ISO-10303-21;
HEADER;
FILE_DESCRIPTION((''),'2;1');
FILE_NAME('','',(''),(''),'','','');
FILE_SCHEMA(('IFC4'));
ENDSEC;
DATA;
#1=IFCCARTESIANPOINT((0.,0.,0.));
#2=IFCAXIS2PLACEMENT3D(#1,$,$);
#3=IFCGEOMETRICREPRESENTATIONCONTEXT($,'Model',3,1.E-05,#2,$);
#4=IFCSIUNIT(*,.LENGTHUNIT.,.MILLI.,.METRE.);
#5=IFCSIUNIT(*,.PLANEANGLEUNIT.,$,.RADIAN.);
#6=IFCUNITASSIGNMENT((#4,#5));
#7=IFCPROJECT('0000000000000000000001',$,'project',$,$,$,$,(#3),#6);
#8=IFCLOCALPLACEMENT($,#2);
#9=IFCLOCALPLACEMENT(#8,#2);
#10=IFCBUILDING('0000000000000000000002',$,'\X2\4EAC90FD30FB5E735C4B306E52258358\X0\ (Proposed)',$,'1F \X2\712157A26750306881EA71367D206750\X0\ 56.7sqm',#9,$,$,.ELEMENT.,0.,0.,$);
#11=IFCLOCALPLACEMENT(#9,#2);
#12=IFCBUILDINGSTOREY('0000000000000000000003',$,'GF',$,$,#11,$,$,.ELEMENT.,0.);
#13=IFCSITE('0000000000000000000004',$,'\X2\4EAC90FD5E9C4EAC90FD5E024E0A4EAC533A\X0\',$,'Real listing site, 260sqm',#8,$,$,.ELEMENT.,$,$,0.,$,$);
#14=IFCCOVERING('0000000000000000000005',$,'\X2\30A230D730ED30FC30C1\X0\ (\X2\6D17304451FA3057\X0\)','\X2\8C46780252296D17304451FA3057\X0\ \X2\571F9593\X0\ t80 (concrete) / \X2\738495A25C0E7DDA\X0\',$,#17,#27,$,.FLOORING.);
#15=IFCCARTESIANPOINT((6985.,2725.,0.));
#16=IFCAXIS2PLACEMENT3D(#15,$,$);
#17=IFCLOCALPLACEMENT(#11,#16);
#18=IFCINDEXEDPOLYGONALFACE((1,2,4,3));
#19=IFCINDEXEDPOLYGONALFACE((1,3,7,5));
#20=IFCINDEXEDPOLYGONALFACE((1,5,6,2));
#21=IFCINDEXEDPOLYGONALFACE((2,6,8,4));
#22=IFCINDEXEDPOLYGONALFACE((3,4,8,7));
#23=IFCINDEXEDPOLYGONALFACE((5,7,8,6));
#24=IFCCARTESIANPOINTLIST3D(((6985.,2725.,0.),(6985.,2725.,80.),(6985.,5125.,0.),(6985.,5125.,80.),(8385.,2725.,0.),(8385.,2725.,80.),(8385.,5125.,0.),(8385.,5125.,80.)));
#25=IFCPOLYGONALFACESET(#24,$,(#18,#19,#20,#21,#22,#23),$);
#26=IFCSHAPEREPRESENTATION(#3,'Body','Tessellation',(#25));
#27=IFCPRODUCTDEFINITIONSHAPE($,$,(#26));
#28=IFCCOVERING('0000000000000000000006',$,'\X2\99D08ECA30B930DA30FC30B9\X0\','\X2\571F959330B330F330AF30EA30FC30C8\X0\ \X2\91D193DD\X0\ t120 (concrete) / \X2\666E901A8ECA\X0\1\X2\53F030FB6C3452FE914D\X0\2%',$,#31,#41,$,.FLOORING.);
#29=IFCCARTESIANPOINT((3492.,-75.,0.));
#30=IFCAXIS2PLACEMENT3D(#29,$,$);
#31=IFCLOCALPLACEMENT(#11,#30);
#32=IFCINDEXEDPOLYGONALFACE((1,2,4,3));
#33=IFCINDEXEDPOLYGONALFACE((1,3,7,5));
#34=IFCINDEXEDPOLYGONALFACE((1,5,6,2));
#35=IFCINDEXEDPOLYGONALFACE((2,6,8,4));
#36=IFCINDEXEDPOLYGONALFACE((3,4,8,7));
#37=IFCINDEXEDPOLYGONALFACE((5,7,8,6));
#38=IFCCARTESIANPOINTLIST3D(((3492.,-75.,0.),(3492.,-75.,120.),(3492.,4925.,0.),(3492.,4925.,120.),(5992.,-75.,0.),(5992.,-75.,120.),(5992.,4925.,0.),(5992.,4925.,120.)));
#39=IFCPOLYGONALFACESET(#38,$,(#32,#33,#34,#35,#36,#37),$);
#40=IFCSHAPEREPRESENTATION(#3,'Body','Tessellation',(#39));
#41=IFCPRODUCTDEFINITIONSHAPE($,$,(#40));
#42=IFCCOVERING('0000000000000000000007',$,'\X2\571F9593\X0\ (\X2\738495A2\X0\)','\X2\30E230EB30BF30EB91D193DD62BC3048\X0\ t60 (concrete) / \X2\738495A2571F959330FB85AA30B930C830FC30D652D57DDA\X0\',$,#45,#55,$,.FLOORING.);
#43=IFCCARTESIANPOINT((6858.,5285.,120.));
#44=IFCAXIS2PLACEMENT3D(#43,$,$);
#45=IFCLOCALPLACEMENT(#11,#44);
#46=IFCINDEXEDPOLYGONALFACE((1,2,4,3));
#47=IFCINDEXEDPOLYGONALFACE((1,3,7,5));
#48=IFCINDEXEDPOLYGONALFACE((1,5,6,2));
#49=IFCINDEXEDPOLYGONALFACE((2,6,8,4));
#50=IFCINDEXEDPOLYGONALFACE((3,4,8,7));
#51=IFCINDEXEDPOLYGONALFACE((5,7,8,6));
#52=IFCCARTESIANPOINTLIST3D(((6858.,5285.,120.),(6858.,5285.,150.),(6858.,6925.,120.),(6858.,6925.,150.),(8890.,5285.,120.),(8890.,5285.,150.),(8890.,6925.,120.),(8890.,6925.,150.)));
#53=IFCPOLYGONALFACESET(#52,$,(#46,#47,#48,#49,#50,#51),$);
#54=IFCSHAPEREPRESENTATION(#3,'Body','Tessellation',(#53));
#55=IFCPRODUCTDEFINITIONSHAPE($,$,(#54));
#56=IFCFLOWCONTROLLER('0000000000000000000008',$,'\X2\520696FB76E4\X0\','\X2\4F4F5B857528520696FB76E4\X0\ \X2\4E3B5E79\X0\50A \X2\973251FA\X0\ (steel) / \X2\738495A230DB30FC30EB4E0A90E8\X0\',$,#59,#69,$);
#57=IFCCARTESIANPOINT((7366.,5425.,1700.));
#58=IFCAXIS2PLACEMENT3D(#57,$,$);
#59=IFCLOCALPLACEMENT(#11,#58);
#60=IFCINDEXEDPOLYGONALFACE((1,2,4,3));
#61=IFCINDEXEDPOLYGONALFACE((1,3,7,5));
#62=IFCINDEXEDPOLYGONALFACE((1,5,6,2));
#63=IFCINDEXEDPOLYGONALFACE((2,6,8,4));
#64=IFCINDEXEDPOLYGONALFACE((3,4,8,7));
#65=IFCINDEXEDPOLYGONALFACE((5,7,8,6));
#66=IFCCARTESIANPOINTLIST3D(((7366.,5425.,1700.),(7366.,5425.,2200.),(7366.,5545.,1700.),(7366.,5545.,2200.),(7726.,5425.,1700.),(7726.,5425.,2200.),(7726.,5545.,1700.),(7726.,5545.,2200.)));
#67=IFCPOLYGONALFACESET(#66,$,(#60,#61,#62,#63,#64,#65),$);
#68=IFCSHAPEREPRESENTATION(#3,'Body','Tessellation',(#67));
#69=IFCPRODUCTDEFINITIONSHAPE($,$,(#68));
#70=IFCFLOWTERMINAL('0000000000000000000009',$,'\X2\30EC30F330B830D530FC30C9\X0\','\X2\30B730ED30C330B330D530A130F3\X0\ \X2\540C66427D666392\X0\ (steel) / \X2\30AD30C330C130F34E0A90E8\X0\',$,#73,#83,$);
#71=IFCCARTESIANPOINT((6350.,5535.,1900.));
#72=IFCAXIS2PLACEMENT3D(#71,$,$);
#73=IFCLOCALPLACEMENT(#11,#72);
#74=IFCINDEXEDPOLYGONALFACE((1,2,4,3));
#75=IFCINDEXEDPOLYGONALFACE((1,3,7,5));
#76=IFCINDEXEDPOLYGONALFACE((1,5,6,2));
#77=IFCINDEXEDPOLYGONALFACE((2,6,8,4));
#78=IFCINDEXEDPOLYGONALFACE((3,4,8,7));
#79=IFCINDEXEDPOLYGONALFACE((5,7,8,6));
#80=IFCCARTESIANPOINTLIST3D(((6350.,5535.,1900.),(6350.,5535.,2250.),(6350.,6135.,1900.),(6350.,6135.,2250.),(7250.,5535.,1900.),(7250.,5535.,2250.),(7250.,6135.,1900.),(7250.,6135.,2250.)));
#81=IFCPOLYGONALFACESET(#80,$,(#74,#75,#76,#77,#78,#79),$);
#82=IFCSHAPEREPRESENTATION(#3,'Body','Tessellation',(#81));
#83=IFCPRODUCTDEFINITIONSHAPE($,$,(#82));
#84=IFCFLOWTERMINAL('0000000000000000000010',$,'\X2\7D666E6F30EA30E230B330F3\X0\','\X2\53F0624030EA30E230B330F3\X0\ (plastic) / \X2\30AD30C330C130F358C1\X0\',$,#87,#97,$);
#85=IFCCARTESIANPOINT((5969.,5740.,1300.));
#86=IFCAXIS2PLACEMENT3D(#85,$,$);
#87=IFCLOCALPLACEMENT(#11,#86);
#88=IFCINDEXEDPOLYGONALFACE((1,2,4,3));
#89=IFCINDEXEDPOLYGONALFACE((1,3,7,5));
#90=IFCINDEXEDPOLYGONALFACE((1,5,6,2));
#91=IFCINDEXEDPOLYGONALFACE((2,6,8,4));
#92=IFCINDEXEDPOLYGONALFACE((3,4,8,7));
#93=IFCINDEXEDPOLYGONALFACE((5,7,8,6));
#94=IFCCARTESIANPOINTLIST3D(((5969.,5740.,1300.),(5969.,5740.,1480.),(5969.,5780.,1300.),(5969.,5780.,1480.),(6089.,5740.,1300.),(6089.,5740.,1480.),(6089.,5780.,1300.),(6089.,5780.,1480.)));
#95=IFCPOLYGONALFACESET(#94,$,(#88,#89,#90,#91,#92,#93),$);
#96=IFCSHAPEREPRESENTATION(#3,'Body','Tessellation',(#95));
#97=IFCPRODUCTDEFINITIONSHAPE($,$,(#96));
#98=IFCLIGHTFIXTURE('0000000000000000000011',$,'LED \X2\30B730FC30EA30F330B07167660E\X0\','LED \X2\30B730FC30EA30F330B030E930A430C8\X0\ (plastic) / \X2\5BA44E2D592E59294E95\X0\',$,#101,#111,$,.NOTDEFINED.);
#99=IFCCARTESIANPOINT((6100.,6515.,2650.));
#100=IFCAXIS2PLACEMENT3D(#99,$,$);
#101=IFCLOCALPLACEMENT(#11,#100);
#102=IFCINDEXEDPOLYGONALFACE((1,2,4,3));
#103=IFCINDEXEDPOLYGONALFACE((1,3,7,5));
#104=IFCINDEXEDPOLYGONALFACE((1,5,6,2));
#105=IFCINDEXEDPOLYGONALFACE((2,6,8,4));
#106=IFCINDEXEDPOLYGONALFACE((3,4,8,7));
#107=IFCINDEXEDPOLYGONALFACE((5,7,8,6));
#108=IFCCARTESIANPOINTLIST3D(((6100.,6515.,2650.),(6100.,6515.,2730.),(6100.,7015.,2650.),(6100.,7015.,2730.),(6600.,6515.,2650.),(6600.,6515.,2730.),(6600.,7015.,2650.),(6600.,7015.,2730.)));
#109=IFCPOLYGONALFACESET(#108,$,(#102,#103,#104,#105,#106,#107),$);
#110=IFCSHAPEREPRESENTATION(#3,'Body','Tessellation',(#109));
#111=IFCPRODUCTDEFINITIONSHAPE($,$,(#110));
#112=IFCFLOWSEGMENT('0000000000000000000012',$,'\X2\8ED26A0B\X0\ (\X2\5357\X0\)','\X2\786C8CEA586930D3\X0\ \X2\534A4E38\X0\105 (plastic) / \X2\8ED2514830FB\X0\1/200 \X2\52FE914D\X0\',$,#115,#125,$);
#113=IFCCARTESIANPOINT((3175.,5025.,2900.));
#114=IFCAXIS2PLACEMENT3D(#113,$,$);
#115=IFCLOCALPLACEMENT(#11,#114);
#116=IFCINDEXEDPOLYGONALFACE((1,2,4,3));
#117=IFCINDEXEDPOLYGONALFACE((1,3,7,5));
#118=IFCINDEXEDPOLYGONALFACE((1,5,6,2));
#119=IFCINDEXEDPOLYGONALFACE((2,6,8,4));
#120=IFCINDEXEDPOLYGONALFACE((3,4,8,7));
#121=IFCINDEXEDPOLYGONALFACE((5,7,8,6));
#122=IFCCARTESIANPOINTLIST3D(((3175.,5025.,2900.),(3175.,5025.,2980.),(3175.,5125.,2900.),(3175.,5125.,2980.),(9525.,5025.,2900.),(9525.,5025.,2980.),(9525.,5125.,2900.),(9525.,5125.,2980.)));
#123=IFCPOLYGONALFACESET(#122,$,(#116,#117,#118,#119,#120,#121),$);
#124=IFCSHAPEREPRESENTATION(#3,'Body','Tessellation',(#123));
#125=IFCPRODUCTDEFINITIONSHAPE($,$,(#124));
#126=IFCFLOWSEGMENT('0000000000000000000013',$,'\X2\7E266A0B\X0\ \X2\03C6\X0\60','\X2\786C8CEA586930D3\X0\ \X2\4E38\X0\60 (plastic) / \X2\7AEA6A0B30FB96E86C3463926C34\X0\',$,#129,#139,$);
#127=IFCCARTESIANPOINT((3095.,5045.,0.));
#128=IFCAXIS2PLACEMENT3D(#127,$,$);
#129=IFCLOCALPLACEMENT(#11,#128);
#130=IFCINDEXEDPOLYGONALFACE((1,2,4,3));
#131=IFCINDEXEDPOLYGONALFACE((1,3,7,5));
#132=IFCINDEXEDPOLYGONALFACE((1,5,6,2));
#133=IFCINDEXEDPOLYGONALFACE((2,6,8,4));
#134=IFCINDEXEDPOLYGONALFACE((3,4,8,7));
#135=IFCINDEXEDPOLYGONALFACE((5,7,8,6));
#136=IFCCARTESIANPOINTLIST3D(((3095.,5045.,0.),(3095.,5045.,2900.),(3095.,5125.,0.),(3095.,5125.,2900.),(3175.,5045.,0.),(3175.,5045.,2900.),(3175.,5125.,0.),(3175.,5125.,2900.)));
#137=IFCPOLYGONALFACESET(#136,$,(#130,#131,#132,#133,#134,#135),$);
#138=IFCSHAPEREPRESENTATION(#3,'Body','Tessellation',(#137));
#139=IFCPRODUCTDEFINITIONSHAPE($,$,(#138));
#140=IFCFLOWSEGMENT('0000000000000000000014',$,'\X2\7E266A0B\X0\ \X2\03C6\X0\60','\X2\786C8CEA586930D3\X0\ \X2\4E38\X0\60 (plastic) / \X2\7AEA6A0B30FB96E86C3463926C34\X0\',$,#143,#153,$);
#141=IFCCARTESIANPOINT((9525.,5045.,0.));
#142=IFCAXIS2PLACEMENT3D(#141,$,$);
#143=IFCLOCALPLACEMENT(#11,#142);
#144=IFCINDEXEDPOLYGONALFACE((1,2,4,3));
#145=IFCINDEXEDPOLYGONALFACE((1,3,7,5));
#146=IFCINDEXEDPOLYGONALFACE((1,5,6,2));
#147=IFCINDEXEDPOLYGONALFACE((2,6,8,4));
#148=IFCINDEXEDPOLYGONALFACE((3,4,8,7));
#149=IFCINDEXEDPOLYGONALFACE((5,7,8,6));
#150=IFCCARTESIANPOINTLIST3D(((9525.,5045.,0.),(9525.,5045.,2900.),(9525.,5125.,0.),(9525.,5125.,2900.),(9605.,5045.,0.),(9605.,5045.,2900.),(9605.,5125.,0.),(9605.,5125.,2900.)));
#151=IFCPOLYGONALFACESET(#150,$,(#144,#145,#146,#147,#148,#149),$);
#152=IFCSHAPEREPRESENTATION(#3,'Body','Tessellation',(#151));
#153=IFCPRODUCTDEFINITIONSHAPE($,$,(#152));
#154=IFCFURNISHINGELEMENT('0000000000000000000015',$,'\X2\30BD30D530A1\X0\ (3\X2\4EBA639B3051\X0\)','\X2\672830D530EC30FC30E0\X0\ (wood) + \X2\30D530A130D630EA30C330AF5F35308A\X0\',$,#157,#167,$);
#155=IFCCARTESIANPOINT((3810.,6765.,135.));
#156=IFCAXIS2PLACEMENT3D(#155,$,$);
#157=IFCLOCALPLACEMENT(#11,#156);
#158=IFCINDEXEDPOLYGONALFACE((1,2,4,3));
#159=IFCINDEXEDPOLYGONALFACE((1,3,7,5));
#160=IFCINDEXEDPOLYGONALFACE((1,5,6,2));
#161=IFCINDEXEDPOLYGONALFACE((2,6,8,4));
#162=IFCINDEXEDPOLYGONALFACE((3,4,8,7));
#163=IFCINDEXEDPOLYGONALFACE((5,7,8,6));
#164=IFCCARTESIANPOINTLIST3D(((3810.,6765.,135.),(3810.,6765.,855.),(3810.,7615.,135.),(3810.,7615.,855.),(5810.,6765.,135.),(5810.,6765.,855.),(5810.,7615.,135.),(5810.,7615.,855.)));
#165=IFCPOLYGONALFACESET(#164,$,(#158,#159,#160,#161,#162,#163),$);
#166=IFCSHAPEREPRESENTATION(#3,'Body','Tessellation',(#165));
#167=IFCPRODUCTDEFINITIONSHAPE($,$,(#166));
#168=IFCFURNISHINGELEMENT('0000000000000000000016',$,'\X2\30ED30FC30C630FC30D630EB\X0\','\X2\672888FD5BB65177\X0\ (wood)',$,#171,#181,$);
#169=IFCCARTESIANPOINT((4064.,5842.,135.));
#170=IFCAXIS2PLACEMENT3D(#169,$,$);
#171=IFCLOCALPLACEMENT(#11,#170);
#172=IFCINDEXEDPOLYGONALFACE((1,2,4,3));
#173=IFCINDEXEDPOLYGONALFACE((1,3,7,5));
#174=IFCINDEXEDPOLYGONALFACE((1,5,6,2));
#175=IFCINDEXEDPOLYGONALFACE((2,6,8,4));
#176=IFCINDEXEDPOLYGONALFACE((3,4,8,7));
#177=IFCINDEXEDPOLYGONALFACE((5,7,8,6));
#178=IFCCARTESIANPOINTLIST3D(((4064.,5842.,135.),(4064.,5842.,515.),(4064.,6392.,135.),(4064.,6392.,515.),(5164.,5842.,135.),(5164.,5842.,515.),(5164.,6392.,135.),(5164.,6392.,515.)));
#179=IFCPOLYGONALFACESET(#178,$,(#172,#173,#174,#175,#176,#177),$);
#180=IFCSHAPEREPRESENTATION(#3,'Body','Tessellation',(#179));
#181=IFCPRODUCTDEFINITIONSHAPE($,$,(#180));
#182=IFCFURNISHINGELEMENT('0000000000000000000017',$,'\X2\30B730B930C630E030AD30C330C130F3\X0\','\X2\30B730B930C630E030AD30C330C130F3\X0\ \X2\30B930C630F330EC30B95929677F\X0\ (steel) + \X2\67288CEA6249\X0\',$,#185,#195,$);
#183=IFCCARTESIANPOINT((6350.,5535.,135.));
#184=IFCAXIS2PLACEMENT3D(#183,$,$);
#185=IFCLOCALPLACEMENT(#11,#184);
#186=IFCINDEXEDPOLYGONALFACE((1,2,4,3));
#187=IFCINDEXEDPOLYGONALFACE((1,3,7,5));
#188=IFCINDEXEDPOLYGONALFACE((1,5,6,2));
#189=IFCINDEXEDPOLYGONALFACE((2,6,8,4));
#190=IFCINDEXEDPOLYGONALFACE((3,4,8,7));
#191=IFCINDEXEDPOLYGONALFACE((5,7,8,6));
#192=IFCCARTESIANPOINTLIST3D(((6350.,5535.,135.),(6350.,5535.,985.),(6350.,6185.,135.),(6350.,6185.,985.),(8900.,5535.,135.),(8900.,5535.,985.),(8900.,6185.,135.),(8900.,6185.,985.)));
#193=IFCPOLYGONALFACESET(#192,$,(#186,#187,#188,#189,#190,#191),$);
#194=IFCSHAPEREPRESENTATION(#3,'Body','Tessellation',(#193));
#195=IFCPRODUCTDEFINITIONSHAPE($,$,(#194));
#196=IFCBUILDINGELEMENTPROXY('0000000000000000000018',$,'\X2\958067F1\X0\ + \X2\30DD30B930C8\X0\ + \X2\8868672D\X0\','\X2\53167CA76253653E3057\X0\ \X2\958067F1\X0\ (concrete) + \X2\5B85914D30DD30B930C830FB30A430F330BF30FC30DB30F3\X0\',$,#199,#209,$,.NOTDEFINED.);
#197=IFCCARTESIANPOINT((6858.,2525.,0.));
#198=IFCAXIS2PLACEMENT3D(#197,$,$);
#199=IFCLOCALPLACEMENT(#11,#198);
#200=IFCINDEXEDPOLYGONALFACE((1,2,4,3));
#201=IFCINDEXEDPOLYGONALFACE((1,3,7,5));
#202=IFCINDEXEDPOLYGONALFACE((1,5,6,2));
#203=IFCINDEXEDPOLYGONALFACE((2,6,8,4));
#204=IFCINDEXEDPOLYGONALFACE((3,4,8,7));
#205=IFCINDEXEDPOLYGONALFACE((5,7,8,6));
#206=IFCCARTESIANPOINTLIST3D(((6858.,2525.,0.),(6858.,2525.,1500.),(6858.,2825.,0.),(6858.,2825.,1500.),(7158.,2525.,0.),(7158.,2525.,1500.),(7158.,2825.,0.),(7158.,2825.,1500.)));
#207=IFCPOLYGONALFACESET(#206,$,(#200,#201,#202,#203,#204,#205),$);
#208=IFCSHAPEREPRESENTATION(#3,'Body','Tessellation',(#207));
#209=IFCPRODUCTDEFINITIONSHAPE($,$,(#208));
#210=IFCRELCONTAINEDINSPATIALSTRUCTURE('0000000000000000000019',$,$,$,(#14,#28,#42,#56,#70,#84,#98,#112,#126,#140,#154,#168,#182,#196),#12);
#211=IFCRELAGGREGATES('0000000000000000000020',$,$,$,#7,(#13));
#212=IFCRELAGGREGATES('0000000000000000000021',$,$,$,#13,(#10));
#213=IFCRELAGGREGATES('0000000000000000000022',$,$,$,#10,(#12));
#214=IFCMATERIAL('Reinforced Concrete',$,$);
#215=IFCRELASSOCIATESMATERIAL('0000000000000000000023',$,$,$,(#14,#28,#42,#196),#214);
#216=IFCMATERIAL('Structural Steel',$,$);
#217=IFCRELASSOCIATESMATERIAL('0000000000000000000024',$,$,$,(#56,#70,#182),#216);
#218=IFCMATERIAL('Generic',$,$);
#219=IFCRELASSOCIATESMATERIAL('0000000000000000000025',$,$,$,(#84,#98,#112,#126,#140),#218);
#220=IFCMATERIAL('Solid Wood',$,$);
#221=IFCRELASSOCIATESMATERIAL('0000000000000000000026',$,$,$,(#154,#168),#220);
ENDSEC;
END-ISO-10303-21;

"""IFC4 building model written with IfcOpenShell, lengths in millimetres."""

from ifc_helpers import new_model, si_unit, frame, frame_2d, origin, place, context, project, spatial, rectangle, extrude, material, element, save


model = new_model("IFC4")

# Units and contexts
model_context = context("Model", 3, precision=1e-05, world=origin())
ifc_project = project(units=[si_unit("LENGTHUNIT", "METRE", prefix="MILLI"), si_unit("PLANEANGLEUNIT", "RADIAN")], contexts=[model_context])

# Site, building, storey
site_placement = place(None, origin())
site = spatial("IfcSite", under=ifc_project, at=site_placement, Name="京都府京都市上京区", ObjectType="Real listing site, 260sqm", CompositionType="ELEMENT", RefElevation=0.0)
building_placement = place(site_placement, origin())
building = spatial("IfcBuilding", under=site, at=building_placement, Name="京都・平屋の別荘 (Proposed)", ObjectType="1F 無垢材と自然素材 56.7sqm", CompositionType="ELEMENT", ElevationOfRefHeight=0.0, ElevationOfTerrain=0.0)
storey_placement = place(building_placement, origin())
storey = spatial("IfcBuildingStorey", under=building, at=storey_placement, Name="GF", CompositionType="ELEMENT", Elevation=0.0)

# Shared definitions
ifc_material_1 = material(Name="Solid Wood")

# Shared definitions
ifc_material_2 = material(Name="Reinforced Concrete")

# Shared definitions
ifc_material_3 = material(Name="Structural Steel")

# Coverings
ifc_material_4 = material(Name="Generic")
covering_1_placement = place(storey_placement, frame((6985.0, 2725.0, 0.0)))
element("IfcCovering", 1, at=covering_1_placement, inside=storey, material=ifc_material_2, Name="アプローチ (洗い出し)", Description="豆砂利洗い出し 土間 t80 (concrete) / 玄関導線", PredefinedType="FLOORING", context=model_context, shape_type="SweptSolid", body=[
    extrude(rectangle(XDim=1400.0, YDim=2400.0, at=frame_2d((700.0, 1200.0))), frame((6985.0, 2725.0, 0.0)), (0.0, 0.0, 1.0), 80.0),
])
covering_2_placement = place(storey_placement, frame((3492.0, -75.0, 0.0)))
element("IfcCovering", 2, at=covering_2_placement, inside=storey, material=ifc_material_2, Name="駐車スペース", Description="土間コンクリート 金鏝 t120 (concrete) / 普通車1台・水勾配2%", PredefinedType="FLOORING", context=model_context, shape_type="SweptSolid", body=[
    extrude(rectangle(XDim=2500.0, YDim=5000.0, at=frame_2d((1250.0, 2500.0))), frame((3492.0, -75.0, 0.0)), (0.0, 0.0, 1.0), 120.0),
])
covering_3_placement = place(storey_placement, frame((6858.0, 5285.0, 120.0)))
element("IfcCovering", 3, at=covering_3_placement, inside=storey, material=ifc_material_2, Name="土間 (玄関)", Description="モルタル金鏝押え t60 (concrete) / 玄関土間・薪ストーブ動線", PredefinedType="FLOORING", context=model_context, shape_type="SweptSolid", body=[
    extrude(rectangle(XDim=2032.0, YDim=1640.0, at=frame_2d((1016.0, 820.0))), frame((6858.0, 5285.0, 120.0)), (0.0, 0.0, 1.0), 30.0),
])

# Flow controller
flow_controller_placement = place(storey_placement, frame((7366.0, 5425.0, 1700.0)))
element("IfcFlowController", 4, at=flow_controller_placement, inside=storey, material=ifc_material_3, Name="分電盤", Description="住宅用分電盤 主幹50A 露出 (steel) / 玄関ホール上部", context=model_context, shape_type="SweptSolid", body=[
    extrude(rectangle(XDim=360.0, YDim=120.0, at=frame_2d((180.0, 60.0))), frame((7366.0, 5425.0, 1700.0)), (0.0, 0.0, 1.0), 500.0),
])

# Flow terminals
flow_terminal_1_placement = place(storey_placement, frame((6350.0, 5535.0, 1900.0)))
element("IfcFlowTerminal", 5, at=flow_terminal_1_placement, inside=storey, material=ifc_material_3, Name="レンジフード", Description="シロッコファン 同時給排 (steel) / キッチン上部", context=model_context, shape_type="SweptSolid", body=[
    extrude(rectangle(XDim=900.0, YDim=600.0, at=frame_2d((450.0, 300.0))), frame((6350.0, 5535.0, 1900.0)), (0.0, 0.0, 1.0), 350.0),
])
flow_terminal_2_placement = place(storey_placement, frame((5969.0, 5740.0, 1300.0)))
element("IfcFlowTerminal", 6, at=flow_terminal_2_placement, inside=storey, material=ifc_material_4, Name="給湯リモコン", Description="台所リモコン (plastic) / キッチン壁", context=model_context, shape_type="SweptSolid", body=[
    extrude(rectangle(XDim=120.0, YDim=40.0, at=frame_2d((60.0, 20.0))), frame((5969.0, 5740.0, 1300.0)), (0.0, 0.0, 1.0), 180.0),
])

# Light fixture
light_fixture_placement = place(storey_placement, frame((6100.0, 6515.0, 2650.0)))
element("IfcLightFixture", 7, at=light_fixture_placement, inside=storey, material=ifc_material_4, Name="LED シーリング照明", Description="LED シーリングライト (plastic) / 室中央天井", PredefinedType="NOTDEFINED", context=model_context, shape_type="SweptSolid", body=[
    extrude(rectangle(XDim=500.0, YDim=500.0, at=frame_2d((250.0, 250.0))), frame((6100.0, 6515.0, 2650.0)), (0.0, 0.0, 1.0), 80.0),
])

# Flow segments
flow_segment_1_placement = place(storey_placement, frame((3175.0, 5025.0, 2900.0)))
element("IfcFlowSegment", 8, at=flow_segment_1_placement, inside=storey, material=ifc_material_4, Name="軒樋 (南)", Description="硬質塩ビ 半丸105 (plastic) / 軒先・1/200 勾配", context=model_context, shape_type="SweptSolid", body=[
    extrude(rectangle(XDim=6350.0, YDim=100.0, at=frame_2d((3175.0, 50.0))), frame((3175.0, 5025.0, 2900.0)), (0.0, 0.0, 1.0), 80.0),
])
flow_segment_2_placement = place(storey_placement, frame((3095.0, 5045.0, 0.0)))
element("IfcFlowSegment", 9, at=flow_segment_2_placement, inside=storey, material=ifc_material_4, Name="縦樋 φ60", Description="硬質塩ビ 丸60 (plastic) / 竪樋・雨水排水", context=model_context, shape_type="SweptSolid", body=[
    extrude(rectangle(XDim=80.0, YDim=80.0, at=frame_2d((40.0, 40.0))), frame((3095.0, 5045.0, 0.0)), (0.0, 0.0, 1.0), 2900.0),
])
flow_segment_3_placement = place(storey_placement, frame((9525.0, 5045.0, 0.0)))
element("IfcFlowSegment", 10, at=flow_segment_3_placement, inside=storey, material=ifc_material_4, Name="縦樋 φ60", Description="硬質塩ビ 丸60 (plastic) / 竪樋・雨水排水", context=model_context, shape_type="SweptSolid", body=[
    extrude(rectangle(XDim=80.0, YDim=80.0, at=frame_2d((40.0, 40.0))), frame((9525.0, 5045.0, 0.0)), (0.0, 0.0, 1.0), 2900.0),
])

# Furnishing elements
furnishing_1_placement = place(storey_placement, frame((3810.0, 6765.0, 135.0)))
element("IfcFurnishingElement", 11, at=furnishing_1_placement, inside=storey, material=ifc_material_1, Name="ソファ (3人掛け)", Description="木フレーム (wood) + ファブリック張り", context=model_context, shape_type="SweptSolid", body=[
    extrude(rectangle(XDim=2000.0, YDim=850.0, at=frame_2d((1000.0, 425.0))), frame((3810.0, 6765.0, 135.0)), (0.0, 0.0, 1.0), 720.0),
])
furnishing_2_placement = place(storey_placement, frame((4064.0, 5842.0, 135.0)))
element("IfcFurnishingElement", 12, at=furnishing_2_placement, inside=storey, material=ifc_material_1, Name="ローテーブル", Description="木製家具 (wood)", context=model_context, shape_type="SweptSolid", body=[
    extrude(rectangle(XDim=1100.0, YDim=550.0, at=frame_2d((550.0, 275.0))), frame((4064.0, 5842.0, 135.0)), (0.0, 0.0, 1.0), 380.0),
])
furnishing_3_placement = place(storey_placement, frame((6350.0, 5535.0, 135.0)))
element("IfcFurnishingElement", 13, at=furnishing_3_placement, inside=storey, material=ifc_material_3, Name="システムキッチン", Description="システムキッチン ステンレス天板 (steel) + 木質扉", context=model_context, shape_type="SweptSolid", body=[
    extrude(rectangle(XDim=2550.0, YDim=650.0, at=frame_2d((1275.0, 325.0))), frame((6350.0, 5535.0, 135.0)), (0.0, 0.0, 1.0), 850.0),
])

# Building element proxy
proxy_placement = place(storey_placement, frame((6858.0, 2525.0, 0.0)))
element("IfcBuildingElementProxy", 14, at=proxy_placement, inside=storey, material=ifc_material_2, Name="門柱 + ポスト + 表札", Description="化粧打放し 門柱 (concrete) + 宅配ポスト・インターホン", PredefinedType="NOTDEFINED", context=model_context, shape_type="SweptSolid", body=[
    extrude(rectangle(XDim=300.0, YDim=300.0, at=frame_2d((150.0, 150.0))), frame((6858.0, 2525.0, 0.0)), (0.0, 0.0, 1.0), 1500.0),
])

save(model, "model.ifc")
